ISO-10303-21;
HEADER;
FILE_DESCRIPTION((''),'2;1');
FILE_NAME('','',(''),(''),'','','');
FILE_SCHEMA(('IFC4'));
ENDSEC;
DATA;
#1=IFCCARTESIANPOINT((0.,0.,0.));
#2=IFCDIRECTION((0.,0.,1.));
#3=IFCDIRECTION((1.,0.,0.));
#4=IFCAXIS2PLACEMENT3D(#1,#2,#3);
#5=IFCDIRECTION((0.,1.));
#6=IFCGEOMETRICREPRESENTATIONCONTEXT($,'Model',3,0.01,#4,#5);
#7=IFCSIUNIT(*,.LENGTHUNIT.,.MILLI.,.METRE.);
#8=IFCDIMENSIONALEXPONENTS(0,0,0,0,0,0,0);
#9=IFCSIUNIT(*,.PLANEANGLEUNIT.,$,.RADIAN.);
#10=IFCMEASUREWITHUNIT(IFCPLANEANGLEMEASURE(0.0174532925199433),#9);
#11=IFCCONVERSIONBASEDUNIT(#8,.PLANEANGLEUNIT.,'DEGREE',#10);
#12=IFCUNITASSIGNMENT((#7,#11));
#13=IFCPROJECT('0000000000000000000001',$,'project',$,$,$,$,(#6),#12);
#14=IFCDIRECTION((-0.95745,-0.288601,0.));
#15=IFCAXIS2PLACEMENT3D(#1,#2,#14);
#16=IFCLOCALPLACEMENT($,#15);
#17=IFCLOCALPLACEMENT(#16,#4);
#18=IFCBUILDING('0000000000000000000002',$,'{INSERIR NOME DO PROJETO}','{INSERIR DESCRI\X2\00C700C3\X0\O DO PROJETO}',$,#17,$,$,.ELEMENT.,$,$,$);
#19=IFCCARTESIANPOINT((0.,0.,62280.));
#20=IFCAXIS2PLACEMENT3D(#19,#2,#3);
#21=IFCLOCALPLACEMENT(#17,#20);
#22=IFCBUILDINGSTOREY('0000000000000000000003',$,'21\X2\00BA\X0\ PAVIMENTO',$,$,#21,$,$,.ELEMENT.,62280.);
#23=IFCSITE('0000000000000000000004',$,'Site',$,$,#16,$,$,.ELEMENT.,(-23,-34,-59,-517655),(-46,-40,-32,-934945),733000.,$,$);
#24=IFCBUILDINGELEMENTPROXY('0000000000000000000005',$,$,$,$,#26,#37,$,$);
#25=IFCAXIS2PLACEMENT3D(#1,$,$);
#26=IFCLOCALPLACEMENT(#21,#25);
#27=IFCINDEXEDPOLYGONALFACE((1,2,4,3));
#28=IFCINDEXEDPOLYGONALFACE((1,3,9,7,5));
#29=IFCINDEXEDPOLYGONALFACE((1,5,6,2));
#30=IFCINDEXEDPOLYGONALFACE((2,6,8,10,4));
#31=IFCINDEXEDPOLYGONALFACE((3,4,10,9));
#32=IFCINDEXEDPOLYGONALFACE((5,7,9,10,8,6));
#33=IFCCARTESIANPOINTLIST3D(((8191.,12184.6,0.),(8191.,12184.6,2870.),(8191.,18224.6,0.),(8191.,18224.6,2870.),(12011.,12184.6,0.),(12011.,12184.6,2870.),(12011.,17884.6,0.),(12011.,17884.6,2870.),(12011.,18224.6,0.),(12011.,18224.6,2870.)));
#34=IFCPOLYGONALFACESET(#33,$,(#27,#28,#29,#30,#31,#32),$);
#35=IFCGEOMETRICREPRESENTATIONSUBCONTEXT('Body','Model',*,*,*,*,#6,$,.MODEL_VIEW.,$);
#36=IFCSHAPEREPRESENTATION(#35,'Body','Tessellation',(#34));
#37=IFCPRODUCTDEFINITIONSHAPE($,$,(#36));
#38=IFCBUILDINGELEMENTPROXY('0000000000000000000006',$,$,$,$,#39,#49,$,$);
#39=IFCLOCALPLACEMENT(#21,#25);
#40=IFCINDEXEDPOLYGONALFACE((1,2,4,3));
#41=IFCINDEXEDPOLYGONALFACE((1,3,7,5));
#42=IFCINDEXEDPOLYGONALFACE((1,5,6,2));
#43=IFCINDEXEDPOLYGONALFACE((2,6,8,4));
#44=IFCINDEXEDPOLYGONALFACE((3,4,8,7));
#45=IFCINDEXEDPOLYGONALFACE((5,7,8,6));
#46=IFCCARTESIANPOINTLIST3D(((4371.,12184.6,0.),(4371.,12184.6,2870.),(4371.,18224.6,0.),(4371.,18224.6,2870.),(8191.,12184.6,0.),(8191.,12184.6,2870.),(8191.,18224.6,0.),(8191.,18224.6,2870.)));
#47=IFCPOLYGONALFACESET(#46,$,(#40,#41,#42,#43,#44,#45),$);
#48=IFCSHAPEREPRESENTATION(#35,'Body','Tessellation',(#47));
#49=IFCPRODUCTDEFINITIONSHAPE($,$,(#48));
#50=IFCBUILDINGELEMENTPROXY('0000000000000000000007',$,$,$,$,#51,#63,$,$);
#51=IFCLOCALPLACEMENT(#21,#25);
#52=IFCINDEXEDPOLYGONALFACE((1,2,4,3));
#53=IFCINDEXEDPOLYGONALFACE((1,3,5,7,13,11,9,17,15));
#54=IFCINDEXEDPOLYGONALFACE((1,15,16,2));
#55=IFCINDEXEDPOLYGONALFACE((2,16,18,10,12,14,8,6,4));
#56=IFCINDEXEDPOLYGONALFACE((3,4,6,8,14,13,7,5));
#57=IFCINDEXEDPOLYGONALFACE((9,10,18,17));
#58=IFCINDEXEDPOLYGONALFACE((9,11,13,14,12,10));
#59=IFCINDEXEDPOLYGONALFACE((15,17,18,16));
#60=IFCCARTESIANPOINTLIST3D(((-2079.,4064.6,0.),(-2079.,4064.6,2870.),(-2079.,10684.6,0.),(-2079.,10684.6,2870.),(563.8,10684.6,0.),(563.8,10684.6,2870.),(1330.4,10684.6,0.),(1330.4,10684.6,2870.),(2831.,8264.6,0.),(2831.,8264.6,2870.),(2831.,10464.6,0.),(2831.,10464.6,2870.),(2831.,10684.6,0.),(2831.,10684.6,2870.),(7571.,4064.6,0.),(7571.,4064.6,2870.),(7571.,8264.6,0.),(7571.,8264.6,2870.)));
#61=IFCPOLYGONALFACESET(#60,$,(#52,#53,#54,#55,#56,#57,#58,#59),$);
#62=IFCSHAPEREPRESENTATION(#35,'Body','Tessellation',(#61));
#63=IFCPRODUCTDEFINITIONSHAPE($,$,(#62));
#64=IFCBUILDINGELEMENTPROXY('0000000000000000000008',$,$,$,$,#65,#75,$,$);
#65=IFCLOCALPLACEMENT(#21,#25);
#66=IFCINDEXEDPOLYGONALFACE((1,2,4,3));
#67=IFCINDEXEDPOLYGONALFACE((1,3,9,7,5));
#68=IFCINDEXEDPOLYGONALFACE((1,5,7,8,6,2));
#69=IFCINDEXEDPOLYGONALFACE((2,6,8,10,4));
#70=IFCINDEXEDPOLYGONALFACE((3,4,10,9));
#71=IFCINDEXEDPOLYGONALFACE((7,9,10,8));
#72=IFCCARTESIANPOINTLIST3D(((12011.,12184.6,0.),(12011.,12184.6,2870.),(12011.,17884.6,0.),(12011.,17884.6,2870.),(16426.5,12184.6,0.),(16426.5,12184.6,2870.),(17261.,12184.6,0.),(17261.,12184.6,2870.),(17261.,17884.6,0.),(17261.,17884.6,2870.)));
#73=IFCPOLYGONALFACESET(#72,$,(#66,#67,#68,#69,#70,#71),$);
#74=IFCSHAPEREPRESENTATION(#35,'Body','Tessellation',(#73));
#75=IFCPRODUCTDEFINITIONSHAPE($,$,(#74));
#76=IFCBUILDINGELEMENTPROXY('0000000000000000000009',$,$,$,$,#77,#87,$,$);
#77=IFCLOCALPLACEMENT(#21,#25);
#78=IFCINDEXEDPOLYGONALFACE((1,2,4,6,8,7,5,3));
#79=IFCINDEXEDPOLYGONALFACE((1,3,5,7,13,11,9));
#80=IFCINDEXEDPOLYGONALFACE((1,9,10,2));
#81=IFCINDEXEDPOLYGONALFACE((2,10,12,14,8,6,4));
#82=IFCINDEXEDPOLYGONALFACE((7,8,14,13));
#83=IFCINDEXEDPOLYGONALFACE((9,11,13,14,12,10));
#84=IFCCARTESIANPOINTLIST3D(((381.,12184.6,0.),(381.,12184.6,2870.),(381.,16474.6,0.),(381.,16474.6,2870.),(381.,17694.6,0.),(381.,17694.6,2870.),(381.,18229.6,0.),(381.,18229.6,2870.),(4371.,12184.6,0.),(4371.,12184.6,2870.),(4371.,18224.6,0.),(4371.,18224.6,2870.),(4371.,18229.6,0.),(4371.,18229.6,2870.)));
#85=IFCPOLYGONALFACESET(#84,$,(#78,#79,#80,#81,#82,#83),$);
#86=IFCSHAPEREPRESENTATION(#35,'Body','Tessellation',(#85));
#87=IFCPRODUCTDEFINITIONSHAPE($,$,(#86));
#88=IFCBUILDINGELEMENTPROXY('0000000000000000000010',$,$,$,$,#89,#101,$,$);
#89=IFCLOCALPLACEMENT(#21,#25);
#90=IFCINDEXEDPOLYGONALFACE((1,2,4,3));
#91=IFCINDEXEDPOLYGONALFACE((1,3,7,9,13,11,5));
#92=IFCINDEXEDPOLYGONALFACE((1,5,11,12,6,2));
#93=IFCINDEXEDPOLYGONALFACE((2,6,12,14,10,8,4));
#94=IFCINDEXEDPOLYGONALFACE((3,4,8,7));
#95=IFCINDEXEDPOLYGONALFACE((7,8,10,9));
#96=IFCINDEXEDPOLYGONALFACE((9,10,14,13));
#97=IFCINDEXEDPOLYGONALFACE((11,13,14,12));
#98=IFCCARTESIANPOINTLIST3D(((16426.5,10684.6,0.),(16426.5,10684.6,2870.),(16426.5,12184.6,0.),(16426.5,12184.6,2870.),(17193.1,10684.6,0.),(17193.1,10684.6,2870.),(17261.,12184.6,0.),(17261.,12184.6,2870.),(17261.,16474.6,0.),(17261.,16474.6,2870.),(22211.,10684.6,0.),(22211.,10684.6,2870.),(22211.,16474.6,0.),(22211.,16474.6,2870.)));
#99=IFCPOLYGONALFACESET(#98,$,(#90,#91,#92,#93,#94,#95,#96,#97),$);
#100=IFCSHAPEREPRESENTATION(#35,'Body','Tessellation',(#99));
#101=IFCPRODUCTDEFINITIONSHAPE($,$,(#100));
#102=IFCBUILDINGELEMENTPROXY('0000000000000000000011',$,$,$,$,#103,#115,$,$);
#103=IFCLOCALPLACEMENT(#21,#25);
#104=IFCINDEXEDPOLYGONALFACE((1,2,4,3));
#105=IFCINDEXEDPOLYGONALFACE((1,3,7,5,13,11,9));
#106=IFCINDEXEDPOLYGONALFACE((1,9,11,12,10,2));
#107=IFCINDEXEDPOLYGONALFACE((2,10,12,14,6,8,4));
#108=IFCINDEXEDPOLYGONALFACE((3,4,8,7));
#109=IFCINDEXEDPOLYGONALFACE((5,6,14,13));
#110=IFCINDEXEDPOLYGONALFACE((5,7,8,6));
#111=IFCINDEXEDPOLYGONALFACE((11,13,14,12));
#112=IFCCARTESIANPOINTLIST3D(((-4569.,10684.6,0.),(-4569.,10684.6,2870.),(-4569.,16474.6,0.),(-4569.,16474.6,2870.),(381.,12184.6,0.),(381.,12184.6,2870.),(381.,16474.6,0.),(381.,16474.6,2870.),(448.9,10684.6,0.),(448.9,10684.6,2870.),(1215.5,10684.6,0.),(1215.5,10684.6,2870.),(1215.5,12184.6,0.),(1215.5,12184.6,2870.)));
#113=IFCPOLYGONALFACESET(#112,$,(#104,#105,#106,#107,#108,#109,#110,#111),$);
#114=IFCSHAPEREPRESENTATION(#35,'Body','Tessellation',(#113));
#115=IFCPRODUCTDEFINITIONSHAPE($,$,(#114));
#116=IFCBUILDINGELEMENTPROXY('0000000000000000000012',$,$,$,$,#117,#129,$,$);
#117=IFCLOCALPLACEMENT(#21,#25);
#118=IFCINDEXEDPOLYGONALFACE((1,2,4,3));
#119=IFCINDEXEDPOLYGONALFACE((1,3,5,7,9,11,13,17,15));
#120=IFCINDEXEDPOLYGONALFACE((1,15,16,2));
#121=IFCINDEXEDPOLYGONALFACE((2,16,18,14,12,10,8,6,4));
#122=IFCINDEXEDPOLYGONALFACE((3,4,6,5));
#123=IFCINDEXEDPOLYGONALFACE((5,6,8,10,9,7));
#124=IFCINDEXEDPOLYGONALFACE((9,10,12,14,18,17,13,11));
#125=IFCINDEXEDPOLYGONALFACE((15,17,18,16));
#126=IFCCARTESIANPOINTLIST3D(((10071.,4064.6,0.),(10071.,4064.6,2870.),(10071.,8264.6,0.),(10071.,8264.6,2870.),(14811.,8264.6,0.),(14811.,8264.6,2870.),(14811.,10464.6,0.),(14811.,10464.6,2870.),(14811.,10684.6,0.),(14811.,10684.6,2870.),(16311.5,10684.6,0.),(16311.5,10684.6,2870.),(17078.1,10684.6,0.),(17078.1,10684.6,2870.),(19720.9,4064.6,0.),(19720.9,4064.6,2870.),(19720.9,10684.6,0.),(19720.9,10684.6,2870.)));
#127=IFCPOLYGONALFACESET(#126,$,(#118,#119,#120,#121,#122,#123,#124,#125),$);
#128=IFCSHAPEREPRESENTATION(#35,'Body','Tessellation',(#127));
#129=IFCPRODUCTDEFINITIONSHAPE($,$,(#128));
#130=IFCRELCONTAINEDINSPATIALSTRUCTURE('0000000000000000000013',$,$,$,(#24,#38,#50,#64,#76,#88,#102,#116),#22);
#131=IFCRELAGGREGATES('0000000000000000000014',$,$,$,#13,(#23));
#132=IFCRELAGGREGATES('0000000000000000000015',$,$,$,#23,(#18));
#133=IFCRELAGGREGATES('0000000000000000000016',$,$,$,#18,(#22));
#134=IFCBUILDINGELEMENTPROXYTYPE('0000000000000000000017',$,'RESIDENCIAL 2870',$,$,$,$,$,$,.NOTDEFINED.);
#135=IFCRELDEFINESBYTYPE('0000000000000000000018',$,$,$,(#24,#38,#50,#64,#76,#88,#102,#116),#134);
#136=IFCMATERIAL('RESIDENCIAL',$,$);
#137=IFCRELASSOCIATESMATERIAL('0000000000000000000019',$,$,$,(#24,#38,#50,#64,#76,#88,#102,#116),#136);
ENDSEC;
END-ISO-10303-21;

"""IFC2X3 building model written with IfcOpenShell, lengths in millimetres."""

from ifc_helpers import new_model, entity, si_unit, converted_unit, direction, frame, origin_with_axes, place, context, subcontext, project, spatial, polyline, outline, extrude, material, type_object, element, save


model = new_model("IFC2X3")

# Units and contexts
model_context = context("Model", 3, precision=0.01, world=origin_with_axes(), true_north=direction((0.0, 1.0)))
body_context = subcontext(model_context, "Body", "Model", "MODEL_VIEW")
ifc_project = project(units=[si_unit("LENGTHUNIT", "METRE", prefix="MILLI"), converted_unit("PLANEANGLEUNIT", "DEGREE", entity("IfcPlaneAngleMeasure", 0.0174532925199433), si_unit("PLANEANGLEUNIT", "RADIAN"), dimensions=[0, 0, 0, 0, 0, 0, 0])], contexts=[model_context])

# Site, building, storey
site_placement = place(None, frame((0.0, 0.0, 0.0), z_axis=(0.0, 0.0, 1.0), x_axis=(-0.95745, -0.288601, 0.0)))
site = spatial("IfcSite", under=ifc_project, at=site_placement, Name="Site", CompositionType="ELEMENT", RefLatitude=(-23, -34, -59, -517655), RefLongitude=(-46, -40, -32, -934945), RefElevation=733000.0)
building_placement = place(site_placement, origin_with_axes())
building = spatial("IfcBuilding", under=site, at=building_placement, Name="{INSERIR NOME DO PROJETO}", Description="{INSERIR DESCRIÇÃO DO PROJETO}", CompositionType="ELEMENT")
storey_placement = place(building_placement, frame((0.0, 0.0, 62280.0), z_axis=(0.0, 0.0, 1.0), x_axis=(1.0, 0.0, 0.0)))
storey = spatial("IfcBuildingStorey", under=building, at=storey_placement, Name="21º PAVIMENTO", CompositionType="ELEMENT", Elevation=62280.0)

# Building element proxies
ifc_material_1 = material(Name="RESIDENCIAL")
building_element_proxy_type_1 = type_object("IfcBuildingElementProxyType", Name="RESIDENCIAL 2870", PredefinedType="NOTDEFINED")
proxy_1_placement = place(storey_placement, frame((8191.0, 18224.6, 0.0), z_axis=(0.0, 0.0, 1.0), x_axis=(1.0, 0.0, 0.0)))
element("IfcBuildingElementProxy", 1, at=proxy_1_placement, inside=storey, type_object=building_element_proxy_type_1, material=ifc_material_1, context=body_context, shape_type="SweptSolid", body=[
    extrude(outline(polyline([(0.0, 0.0), (0.0, -6040.0), (3820.0, -6040.0), (3820.0, -340.0), (3820.0, 0.0), (0.0, 0.0)])), origin_with_axes(), (0.0, 0.0, 1.0), 2870.0),
])
proxy_2_placement = place(storey_placement, frame((4371.0, 18224.6, 0.0), z_axis=(0.0, 0.0, 1.0), x_axis=(1.0, 0.0, 0.0)))
element("IfcBuildingElementProxy", 2, at=proxy_2_placement, inside=storey, type_object=building_element_proxy_type_1, material=ifc_material_1, context=body_context, shape_type="SweptSolid", body=[
    extrude(outline(polyline([(0.0, 0.0), (0.0, -6040.0), (3820.0, -6040.0), (3820.0, 0.0), (0.0, 0.0)])), origin_with_axes(), (0.0, 0.0, 1.0), 2870.0),
])
proxy_3_placement = place(storey_placement, frame((-2079.0, 4064.6, 0.0), z_axis=(0.0, 0.0, 1.0), x_axis=(1.0, 0.0, 0.0)))
element("IfcBuildingElementProxy", 3, at=proxy_3_placement, inside=storey, type_object=building_element_proxy_type_1, material=ifc_material_1, context=body_context, shape_type="SweptSolid", body=[
    extrude(outline(polyline([(0.0, 0.0), (9650.0, 0.0), (9650.0, 4200.0), (4910.0, 4200.0), (4910.0, 6400.0), (4910.0, 6620.0), (3409.4, 6620.0), (2642.8, 6620.0), (0.0, 6620.0), (0.0, 0.0)])), origin_with_axes(), (0.0, 0.0, 1.0), 2870.0),
])
proxy_4_placement = place(storey_placement, frame((12011.0, 12184.6, 0.0), z_axis=(0.0, 0.0, 1.0), x_axis=(1.0, 0.0, 0.0)))
element("IfcBuildingElementProxy", 4, at=proxy_4_placement, inside=storey, type_object=building_element_proxy_type_1, material=ifc_material_1, context=body_context, shape_type="SweptSolid", body=[
    extrude(outline(polyline([(0.0, 0.0), (4415.5, 0.0), (5250.0, 0.0), (5250.0, 5700.0), (0.0, 5700.0), (0.0, 0.0)])), origin_with_axes(), (0.0, 0.0, 1.0), 2870.0),
])
proxy_5_placement = place(storey_placement, frame((381.0, 16474.6, 0.0), z_axis=(0.0, 0.0, 1.0), x_axis=(1.0, 0.0, 0.0)))
element("IfcBuildingElementProxy", 5, at=proxy_5_placement, inside=storey, type_object=building_element_proxy_type_1, material=ifc_material_1, context=body_context, shape_type="SweptSolid", body=[
    extrude(outline(polyline([(0.0, 0.0), (0.0, -4290.0), (3990.0, -4290.0), (3990.0, 1750.0), (3990.0, 1755.0), (0.0, 1755.0), (0.0, 1220.0), (0.0, 0.0)])), origin_with_axes(), (0.0, 0.0, 1.0), 2870.0),
])
proxy_6_placement = place(storey_placement, frame((17261.0, 12184.6, 0.0), z_axis=(0.0, 0.0, 1.0), x_axis=(1.0, 0.0, 0.0)))
element("IfcBuildingElementProxy", 6, at=proxy_6_placement, inside=storey, type_object=building_element_proxy_type_1, material=ifc_material_1, context=body_context, shape_type="SweptSolid", body=[
    extrude(outline(polyline([(0.0, 0.0), (-834.5, 0.0), (-834.5, -1500.0), (-67.9, -1500.0), (4950.0, -1500.0), (4950.0, 4290.0), (0.0, 4290.0), (0.0, 0.0)])), origin_with_axes(), (0.0, 0.0, 1.0), 2870.0),
])
proxy_7_placement = place(storey_placement, frame((-4569.0, 16474.6, 0.0), z_axis=(0.0, 0.0, 1.0), x_axis=(1.0, 0.0, 0.0)))
element("IfcBuildingElementProxy", 7, at=proxy_7_placement, inside=storey, type_object=building_element_proxy_type_1, material=ifc_material_1, context=body_context, shape_type="SweptSolid", body=[
    extrude(outline(polyline([(0.0, 0.0), (0.0, -5790.0), (5017.9, -5790.0), (5784.5, -5790.0), (5784.5, -4290.0), (4950.0, -4290.0), (4950.0, 0.0), (0.0, 0.0)])), origin_with_axes(), (0.0, 0.0, 1.0), 2870.0),
])
proxy_8_placement = place(storey_placement, frame((19720.9, 4064.6, 0.0), z_axis=(0.0, 0.0, 1.0), x_axis=(1.0, 0.0, 0.0)))
element("IfcBuildingElementProxy", 8, at=proxy_8_placement, inside=storey, type_object=building_element_proxy_type_1, material=ifc_material_1, context=body_context, shape_type="SweptSolid", body=[
    extrude(outline(polyline([(0.0, 0.0), (0.0, 6620.0), (-2642.8, 6620.0), (-3409.4, 6620.0), (-4910.0, 6620.0), (-4910.0, 6400.0), (-4910.0, 4200.0), (-9650.0, 4200.0), (-9650.0, 0.0), (0.0, 0.0)])), origin_with_axes(), (0.0, 0.0, 1.0), 2870.0),
])

save(model, "model.ifc")
